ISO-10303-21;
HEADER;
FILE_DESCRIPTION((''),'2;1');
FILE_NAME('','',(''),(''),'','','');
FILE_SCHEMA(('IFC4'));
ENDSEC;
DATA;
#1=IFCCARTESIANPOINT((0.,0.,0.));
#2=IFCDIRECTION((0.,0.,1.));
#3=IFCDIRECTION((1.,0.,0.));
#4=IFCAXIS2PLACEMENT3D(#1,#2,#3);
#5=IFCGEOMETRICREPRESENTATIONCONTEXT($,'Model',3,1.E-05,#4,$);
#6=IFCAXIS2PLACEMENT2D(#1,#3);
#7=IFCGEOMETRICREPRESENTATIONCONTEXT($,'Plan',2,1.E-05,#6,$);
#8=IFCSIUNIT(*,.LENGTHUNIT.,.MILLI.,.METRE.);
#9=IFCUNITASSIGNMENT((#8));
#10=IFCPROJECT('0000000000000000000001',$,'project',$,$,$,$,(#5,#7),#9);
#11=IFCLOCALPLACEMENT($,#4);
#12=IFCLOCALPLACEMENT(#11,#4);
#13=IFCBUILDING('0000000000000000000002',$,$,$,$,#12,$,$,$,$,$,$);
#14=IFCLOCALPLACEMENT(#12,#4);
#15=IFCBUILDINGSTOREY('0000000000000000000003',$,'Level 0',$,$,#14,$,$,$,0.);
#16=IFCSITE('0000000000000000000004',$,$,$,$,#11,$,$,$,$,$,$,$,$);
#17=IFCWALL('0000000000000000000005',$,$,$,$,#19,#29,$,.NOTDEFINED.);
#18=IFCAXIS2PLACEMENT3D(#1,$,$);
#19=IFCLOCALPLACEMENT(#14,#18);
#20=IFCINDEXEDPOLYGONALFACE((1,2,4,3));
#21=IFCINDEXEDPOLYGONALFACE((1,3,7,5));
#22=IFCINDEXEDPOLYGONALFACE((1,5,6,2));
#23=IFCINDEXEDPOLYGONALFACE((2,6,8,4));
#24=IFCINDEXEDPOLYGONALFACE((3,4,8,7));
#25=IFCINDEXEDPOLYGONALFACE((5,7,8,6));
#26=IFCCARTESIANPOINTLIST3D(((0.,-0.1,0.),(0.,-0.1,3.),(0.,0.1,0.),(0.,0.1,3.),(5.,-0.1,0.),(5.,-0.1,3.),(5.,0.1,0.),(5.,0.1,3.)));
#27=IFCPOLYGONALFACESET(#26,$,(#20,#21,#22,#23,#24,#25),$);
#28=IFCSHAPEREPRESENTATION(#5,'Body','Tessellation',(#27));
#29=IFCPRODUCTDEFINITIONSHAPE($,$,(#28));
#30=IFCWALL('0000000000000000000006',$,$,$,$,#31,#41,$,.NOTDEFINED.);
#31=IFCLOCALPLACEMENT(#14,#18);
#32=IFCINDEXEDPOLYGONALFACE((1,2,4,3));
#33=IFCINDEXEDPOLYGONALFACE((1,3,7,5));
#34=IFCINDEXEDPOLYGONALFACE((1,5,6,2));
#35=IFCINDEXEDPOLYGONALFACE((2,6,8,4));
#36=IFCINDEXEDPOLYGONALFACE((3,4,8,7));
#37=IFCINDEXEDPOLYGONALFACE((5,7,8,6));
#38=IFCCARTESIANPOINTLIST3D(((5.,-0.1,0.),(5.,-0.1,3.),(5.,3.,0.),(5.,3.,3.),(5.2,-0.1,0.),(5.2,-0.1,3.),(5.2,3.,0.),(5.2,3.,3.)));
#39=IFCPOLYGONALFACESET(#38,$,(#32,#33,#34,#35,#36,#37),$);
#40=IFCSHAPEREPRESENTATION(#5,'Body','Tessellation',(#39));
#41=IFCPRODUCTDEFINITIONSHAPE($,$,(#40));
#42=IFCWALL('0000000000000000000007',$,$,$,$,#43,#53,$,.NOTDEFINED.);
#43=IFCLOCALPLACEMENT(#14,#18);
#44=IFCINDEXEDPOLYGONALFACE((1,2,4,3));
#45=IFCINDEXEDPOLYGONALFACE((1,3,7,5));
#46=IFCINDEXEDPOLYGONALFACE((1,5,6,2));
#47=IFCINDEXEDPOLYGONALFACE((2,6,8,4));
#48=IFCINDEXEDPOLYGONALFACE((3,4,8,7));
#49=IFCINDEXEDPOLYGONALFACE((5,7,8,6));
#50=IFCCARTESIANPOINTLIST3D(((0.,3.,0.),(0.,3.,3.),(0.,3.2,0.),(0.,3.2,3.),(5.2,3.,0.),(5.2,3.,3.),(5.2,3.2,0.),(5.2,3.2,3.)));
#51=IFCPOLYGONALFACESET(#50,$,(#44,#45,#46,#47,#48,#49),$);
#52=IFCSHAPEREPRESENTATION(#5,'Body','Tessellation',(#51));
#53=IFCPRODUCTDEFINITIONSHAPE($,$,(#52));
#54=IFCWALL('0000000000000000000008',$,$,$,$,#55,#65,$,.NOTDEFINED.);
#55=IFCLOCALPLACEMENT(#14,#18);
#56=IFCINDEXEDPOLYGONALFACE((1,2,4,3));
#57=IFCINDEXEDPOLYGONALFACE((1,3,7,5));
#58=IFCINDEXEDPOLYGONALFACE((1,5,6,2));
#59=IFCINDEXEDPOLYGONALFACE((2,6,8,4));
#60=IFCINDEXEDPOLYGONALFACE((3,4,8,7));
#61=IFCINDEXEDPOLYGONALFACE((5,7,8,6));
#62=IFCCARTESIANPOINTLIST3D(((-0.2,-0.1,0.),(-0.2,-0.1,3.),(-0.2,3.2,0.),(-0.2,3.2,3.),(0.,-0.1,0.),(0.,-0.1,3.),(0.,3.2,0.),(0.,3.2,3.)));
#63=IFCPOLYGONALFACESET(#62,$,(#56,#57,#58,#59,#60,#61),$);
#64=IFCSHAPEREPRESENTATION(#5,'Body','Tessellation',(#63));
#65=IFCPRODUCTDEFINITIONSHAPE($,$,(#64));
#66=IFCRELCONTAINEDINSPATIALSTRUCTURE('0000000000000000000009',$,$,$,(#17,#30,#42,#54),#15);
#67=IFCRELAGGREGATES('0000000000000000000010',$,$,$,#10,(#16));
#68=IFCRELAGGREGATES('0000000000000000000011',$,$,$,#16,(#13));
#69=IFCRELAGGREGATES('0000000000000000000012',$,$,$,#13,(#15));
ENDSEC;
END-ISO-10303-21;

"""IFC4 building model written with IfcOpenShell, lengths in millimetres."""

from ifc_helpers import new_model, si_unit, frame_2d, origin_with_axes, place, context, project, spatial, polyline, outline, extrude, element, save


model = new_model("IFC4")

# Units and contexts
model_context = context("Model", 3, precision=1e-05, world=origin_with_axes())
plan_context = context("Plan", 2, precision=1e-05, world=frame_2d((0.0, 0.0, 0.0), x_axis=(1.0, 0.0, 0.0)))
ifc_project = project(units=[si_unit("LENGTHUNIT", "METRE", prefix="MILLI")], contexts=[model_context, plan_context])

# Site, building, storey
site_placement = place(None, origin_with_axes())
site = spatial("IfcSite", under=ifc_project, at=site_placement)
building_placement = place(site_placement, origin_with_axes())
building = spatial("IfcBuilding", under=site, at=building_placement)
storey_placement = place(building_placement, origin_with_axes())
storey = spatial("IfcBuildingStorey", under=building, at=storey_placement, Name="Level 0", Elevation=0.0)

# Walls
placement = place(storey_placement, origin_with_axes())
element("IfcWall", 1, at=placement, inside=storey, PredefinedType="NOTDEFINED", context=model_context, shape_type="SweptSolid", body=[
    extrude(outline(polyline([(0.0, -0.1, 0.0), (5.0, -0.1, 0.0), (5.0, 0.1, 0.0), (0.0, 0.1, 0.0), (0.0, -0.1, 0.0)])), origin_with_axes(), (0.0, 0.0, 1.0), 3.0),
])
element("IfcWall", 2, at=placement, inside=storey, PredefinedType="NOTDEFINED", context=model_context, shape_type="SweptSolid", body=[
    extrude(outline(polyline([(5.0, -0.1, 0.0), (5.2, -0.1, 0.0), (5.2, 3.0, 0.0), (5.0, 3.0, 0.0), (5.0, -0.1, 0.0)])), origin_with_axes(), (0.0, 0.0, 1.0), 3.0),
])
element("IfcWall", 3, at=placement, inside=storey, PredefinedType="NOTDEFINED", context=model_context, shape_type="SweptSolid", body=[
    extrude(outline(polyline([(5.2, 3.0, 0.0), (5.2, 3.2, 0.0), (0.0, 3.2, 0.0), (0.0, 3.0, 0.0), (5.2, 3.0, 0.0)])), origin_with_axes(), (0.0, 0.0, 1.0), 3.0),
])
element("IfcWall", 4, at=placement, inside=storey, PredefinedType="NOTDEFINED", context=model_context, shape_type="SweptSolid", body=[
    extrude(outline(polyline([(0.0, 3.2, 0.0), (-0.2, 3.2, 0.0), (-0.2, -0.1, 0.0), (0.0, -0.1, 0.0), (0.0, 3.2, 0.0)])), origin_with_axes(), (0.0, 0.0, 1.0), 3.0),
])

save(model, "model.ifc")
